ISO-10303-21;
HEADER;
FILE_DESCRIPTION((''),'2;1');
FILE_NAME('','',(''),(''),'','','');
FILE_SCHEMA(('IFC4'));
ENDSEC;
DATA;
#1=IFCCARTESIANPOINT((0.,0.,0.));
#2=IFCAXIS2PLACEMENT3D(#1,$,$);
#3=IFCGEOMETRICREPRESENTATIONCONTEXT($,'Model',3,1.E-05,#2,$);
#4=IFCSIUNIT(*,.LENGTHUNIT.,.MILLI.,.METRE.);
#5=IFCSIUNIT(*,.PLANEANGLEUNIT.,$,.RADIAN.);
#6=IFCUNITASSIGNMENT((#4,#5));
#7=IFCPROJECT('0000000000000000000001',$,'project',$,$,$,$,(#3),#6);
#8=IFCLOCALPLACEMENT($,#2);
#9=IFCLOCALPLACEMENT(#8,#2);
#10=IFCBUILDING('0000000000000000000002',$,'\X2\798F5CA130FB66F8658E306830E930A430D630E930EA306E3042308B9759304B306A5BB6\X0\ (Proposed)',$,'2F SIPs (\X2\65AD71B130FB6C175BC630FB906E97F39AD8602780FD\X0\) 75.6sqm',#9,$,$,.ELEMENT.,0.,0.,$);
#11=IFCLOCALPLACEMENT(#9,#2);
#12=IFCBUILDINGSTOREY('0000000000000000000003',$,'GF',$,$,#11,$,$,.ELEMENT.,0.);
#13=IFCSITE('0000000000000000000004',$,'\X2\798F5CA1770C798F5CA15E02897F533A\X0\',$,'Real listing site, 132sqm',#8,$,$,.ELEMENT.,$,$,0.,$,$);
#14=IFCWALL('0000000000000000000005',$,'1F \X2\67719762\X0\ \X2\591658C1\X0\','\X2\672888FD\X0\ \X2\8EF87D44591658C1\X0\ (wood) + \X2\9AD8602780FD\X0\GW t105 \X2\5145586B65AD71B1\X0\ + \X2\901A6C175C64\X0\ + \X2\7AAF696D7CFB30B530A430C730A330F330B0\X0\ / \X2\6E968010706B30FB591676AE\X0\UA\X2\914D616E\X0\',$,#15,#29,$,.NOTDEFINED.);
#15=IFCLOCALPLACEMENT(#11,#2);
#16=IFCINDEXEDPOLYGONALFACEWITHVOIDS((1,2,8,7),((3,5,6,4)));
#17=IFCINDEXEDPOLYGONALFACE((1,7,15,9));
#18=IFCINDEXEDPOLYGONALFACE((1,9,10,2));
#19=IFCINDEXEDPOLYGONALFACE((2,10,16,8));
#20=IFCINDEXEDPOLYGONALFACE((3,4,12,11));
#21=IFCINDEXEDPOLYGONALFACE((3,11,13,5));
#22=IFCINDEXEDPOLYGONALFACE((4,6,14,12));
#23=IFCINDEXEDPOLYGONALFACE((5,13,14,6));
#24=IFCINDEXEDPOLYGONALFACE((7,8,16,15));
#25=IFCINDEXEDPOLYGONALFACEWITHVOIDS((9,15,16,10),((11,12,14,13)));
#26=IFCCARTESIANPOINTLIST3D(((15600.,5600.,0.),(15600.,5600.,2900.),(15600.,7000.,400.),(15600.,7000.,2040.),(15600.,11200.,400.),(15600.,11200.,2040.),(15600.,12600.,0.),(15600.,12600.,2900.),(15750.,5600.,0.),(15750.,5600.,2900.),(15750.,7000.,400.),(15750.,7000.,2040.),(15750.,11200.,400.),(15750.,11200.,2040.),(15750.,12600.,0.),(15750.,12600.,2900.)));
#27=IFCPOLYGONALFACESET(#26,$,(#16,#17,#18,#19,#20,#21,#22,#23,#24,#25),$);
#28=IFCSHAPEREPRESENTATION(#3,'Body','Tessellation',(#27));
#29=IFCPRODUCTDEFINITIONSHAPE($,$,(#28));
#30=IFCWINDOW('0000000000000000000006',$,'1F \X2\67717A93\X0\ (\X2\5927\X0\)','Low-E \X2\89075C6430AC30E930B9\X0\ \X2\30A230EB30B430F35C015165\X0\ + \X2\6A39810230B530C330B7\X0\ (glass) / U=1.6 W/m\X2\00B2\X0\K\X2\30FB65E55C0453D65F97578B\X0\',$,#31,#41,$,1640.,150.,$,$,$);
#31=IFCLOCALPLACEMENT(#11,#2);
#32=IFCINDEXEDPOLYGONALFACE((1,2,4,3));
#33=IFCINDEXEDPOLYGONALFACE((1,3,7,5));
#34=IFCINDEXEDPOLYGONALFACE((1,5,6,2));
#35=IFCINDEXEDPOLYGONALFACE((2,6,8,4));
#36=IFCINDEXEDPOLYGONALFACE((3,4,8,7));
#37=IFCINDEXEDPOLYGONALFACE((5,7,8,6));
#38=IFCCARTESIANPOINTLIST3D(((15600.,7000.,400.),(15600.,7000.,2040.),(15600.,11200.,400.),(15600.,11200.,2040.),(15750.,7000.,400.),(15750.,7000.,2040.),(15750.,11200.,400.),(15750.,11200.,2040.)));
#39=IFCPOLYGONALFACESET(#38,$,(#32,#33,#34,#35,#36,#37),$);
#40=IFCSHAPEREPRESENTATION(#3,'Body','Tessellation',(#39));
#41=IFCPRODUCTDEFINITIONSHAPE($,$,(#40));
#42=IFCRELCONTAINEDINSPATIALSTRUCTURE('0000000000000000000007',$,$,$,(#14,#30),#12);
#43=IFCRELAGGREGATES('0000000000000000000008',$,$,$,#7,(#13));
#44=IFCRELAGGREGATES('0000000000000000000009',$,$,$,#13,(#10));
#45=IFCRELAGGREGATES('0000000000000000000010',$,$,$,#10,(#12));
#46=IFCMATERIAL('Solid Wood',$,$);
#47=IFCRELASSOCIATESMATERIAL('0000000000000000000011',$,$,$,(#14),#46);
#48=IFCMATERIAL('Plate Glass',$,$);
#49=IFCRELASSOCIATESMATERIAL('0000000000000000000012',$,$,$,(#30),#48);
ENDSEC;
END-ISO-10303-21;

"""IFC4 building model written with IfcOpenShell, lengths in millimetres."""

from ifc_helpers import new_model, si_unit, frame, frame_2d, origin, place, context, project, spatial, rectangle, extrude, material, element, fill, save


model = new_model("IFC4")

# Units and contexts
model_context = context("Model", 3, precision=1e-05, world=origin())
ifc_project = project(units=[si_unit("LENGTHUNIT", "METRE", prefix="MILLI"), si_unit("PLANEANGLEUNIT", "RADIAN")], contexts=[model_context])

# Site, building, storey
site_placement = place(None, origin())
site = spatial("IfcSite", under=ifc_project, at=site_placement, Name="福岡県福岡市西区", ObjectType="Real listing site, 132sqm", CompositionType="ELEMENT", RefElevation=0.0)
building_placement = place(site_placement, origin())
building = spatial("IfcBuilding", under=site, at=building_placement, Name="福岡・書斎とライブラリのある静かな家 (Proposed)", ObjectType="2F SIPs (断熱・気密・遮音高性能) 75.6sqm", CompositionType="ELEMENT", ElevationOfRefHeight=0.0, ElevationOfTerrain=0.0)
storey_placement = place(building_placement, origin())
storey = spatial("IfcBuildingStorey", under=building, at=storey_placement, Name="GF", CompositionType="ELEMENT", Elevation=0.0)

# Shared definitions
ifc_material_1 = material(Name="Solid Wood")

# Shared definitions
ifc_material_2 = material(Name="Plate Glass")

# Wall, opening, window
wall_1_placement = place(storey_placement, frame((7800.0, 2800.0, 0.0)))
wall_1 = element("IfcWall", 1, at=wall_1_placement, inside=storey, material=ifc_material_1, Name="1F 東面 外壁", Description="木製 軸組外壁 (wood) + 高性能GW t105 充填断熱 + 通気層 + 窯業系サイディング / 準耐火・外皮UA配慮", PredefinedType="NOTDEFINED", context=model_context, shape_type="SweptSolid", body=[
    extrude(rectangle(XDim=150.0, YDim=7000.0, at=frame_2d((75.0, 3500.0))), frame((7800.0, 2800.0, 0.0)), (0.0, 0.0, 1.0), 2900.0),
])
opening_1_placement = place(storey_placement, frame((7800.0, 3500.0, 200.0)))
opening_1 = element("IfcOpeningElement", 2, at=opening_1_placement, cuts=wall_1, PredefinedType="NOTDEFINED", context=model_context, shape_type="SweptSolid", body=[
    extrude(rectangle(XDim=150.0, YDim=4200.0, at=frame_2d((75.0, 2100.0))), frame((7800.0, 3500.0, 200.0)), (0.0, 0.0, 1.0), 1640.0),
])
window_1_placement = place(storey_placement, frame((7800.0, 3500.0, 200.0)))
window_1 = element("IfcWindow", 3, at=window_1_placement, inside=storey, material=ifc_material_2, Name="1F 東窓 (大)", Description="Low-E 複層ガラス アルゴン封入 + 樹脂サッシ (glass) / U=1.6 W/m²K・日射取得型", OverallHeight=1640.0, OverallWidth=150.0, context=model_context, shape_type="SweptSolid", body=[
    extrude(rectangle(XDim=150.0, YDim=4200.0, at=frame_2d((75.0, 2100.0))), frame((7800.0, 3500.0, 200.0)), (0.0, 0.0, 1.0), 1640.0),
])
fill(opening_1, window_1)

save(model, "model.ifc")
